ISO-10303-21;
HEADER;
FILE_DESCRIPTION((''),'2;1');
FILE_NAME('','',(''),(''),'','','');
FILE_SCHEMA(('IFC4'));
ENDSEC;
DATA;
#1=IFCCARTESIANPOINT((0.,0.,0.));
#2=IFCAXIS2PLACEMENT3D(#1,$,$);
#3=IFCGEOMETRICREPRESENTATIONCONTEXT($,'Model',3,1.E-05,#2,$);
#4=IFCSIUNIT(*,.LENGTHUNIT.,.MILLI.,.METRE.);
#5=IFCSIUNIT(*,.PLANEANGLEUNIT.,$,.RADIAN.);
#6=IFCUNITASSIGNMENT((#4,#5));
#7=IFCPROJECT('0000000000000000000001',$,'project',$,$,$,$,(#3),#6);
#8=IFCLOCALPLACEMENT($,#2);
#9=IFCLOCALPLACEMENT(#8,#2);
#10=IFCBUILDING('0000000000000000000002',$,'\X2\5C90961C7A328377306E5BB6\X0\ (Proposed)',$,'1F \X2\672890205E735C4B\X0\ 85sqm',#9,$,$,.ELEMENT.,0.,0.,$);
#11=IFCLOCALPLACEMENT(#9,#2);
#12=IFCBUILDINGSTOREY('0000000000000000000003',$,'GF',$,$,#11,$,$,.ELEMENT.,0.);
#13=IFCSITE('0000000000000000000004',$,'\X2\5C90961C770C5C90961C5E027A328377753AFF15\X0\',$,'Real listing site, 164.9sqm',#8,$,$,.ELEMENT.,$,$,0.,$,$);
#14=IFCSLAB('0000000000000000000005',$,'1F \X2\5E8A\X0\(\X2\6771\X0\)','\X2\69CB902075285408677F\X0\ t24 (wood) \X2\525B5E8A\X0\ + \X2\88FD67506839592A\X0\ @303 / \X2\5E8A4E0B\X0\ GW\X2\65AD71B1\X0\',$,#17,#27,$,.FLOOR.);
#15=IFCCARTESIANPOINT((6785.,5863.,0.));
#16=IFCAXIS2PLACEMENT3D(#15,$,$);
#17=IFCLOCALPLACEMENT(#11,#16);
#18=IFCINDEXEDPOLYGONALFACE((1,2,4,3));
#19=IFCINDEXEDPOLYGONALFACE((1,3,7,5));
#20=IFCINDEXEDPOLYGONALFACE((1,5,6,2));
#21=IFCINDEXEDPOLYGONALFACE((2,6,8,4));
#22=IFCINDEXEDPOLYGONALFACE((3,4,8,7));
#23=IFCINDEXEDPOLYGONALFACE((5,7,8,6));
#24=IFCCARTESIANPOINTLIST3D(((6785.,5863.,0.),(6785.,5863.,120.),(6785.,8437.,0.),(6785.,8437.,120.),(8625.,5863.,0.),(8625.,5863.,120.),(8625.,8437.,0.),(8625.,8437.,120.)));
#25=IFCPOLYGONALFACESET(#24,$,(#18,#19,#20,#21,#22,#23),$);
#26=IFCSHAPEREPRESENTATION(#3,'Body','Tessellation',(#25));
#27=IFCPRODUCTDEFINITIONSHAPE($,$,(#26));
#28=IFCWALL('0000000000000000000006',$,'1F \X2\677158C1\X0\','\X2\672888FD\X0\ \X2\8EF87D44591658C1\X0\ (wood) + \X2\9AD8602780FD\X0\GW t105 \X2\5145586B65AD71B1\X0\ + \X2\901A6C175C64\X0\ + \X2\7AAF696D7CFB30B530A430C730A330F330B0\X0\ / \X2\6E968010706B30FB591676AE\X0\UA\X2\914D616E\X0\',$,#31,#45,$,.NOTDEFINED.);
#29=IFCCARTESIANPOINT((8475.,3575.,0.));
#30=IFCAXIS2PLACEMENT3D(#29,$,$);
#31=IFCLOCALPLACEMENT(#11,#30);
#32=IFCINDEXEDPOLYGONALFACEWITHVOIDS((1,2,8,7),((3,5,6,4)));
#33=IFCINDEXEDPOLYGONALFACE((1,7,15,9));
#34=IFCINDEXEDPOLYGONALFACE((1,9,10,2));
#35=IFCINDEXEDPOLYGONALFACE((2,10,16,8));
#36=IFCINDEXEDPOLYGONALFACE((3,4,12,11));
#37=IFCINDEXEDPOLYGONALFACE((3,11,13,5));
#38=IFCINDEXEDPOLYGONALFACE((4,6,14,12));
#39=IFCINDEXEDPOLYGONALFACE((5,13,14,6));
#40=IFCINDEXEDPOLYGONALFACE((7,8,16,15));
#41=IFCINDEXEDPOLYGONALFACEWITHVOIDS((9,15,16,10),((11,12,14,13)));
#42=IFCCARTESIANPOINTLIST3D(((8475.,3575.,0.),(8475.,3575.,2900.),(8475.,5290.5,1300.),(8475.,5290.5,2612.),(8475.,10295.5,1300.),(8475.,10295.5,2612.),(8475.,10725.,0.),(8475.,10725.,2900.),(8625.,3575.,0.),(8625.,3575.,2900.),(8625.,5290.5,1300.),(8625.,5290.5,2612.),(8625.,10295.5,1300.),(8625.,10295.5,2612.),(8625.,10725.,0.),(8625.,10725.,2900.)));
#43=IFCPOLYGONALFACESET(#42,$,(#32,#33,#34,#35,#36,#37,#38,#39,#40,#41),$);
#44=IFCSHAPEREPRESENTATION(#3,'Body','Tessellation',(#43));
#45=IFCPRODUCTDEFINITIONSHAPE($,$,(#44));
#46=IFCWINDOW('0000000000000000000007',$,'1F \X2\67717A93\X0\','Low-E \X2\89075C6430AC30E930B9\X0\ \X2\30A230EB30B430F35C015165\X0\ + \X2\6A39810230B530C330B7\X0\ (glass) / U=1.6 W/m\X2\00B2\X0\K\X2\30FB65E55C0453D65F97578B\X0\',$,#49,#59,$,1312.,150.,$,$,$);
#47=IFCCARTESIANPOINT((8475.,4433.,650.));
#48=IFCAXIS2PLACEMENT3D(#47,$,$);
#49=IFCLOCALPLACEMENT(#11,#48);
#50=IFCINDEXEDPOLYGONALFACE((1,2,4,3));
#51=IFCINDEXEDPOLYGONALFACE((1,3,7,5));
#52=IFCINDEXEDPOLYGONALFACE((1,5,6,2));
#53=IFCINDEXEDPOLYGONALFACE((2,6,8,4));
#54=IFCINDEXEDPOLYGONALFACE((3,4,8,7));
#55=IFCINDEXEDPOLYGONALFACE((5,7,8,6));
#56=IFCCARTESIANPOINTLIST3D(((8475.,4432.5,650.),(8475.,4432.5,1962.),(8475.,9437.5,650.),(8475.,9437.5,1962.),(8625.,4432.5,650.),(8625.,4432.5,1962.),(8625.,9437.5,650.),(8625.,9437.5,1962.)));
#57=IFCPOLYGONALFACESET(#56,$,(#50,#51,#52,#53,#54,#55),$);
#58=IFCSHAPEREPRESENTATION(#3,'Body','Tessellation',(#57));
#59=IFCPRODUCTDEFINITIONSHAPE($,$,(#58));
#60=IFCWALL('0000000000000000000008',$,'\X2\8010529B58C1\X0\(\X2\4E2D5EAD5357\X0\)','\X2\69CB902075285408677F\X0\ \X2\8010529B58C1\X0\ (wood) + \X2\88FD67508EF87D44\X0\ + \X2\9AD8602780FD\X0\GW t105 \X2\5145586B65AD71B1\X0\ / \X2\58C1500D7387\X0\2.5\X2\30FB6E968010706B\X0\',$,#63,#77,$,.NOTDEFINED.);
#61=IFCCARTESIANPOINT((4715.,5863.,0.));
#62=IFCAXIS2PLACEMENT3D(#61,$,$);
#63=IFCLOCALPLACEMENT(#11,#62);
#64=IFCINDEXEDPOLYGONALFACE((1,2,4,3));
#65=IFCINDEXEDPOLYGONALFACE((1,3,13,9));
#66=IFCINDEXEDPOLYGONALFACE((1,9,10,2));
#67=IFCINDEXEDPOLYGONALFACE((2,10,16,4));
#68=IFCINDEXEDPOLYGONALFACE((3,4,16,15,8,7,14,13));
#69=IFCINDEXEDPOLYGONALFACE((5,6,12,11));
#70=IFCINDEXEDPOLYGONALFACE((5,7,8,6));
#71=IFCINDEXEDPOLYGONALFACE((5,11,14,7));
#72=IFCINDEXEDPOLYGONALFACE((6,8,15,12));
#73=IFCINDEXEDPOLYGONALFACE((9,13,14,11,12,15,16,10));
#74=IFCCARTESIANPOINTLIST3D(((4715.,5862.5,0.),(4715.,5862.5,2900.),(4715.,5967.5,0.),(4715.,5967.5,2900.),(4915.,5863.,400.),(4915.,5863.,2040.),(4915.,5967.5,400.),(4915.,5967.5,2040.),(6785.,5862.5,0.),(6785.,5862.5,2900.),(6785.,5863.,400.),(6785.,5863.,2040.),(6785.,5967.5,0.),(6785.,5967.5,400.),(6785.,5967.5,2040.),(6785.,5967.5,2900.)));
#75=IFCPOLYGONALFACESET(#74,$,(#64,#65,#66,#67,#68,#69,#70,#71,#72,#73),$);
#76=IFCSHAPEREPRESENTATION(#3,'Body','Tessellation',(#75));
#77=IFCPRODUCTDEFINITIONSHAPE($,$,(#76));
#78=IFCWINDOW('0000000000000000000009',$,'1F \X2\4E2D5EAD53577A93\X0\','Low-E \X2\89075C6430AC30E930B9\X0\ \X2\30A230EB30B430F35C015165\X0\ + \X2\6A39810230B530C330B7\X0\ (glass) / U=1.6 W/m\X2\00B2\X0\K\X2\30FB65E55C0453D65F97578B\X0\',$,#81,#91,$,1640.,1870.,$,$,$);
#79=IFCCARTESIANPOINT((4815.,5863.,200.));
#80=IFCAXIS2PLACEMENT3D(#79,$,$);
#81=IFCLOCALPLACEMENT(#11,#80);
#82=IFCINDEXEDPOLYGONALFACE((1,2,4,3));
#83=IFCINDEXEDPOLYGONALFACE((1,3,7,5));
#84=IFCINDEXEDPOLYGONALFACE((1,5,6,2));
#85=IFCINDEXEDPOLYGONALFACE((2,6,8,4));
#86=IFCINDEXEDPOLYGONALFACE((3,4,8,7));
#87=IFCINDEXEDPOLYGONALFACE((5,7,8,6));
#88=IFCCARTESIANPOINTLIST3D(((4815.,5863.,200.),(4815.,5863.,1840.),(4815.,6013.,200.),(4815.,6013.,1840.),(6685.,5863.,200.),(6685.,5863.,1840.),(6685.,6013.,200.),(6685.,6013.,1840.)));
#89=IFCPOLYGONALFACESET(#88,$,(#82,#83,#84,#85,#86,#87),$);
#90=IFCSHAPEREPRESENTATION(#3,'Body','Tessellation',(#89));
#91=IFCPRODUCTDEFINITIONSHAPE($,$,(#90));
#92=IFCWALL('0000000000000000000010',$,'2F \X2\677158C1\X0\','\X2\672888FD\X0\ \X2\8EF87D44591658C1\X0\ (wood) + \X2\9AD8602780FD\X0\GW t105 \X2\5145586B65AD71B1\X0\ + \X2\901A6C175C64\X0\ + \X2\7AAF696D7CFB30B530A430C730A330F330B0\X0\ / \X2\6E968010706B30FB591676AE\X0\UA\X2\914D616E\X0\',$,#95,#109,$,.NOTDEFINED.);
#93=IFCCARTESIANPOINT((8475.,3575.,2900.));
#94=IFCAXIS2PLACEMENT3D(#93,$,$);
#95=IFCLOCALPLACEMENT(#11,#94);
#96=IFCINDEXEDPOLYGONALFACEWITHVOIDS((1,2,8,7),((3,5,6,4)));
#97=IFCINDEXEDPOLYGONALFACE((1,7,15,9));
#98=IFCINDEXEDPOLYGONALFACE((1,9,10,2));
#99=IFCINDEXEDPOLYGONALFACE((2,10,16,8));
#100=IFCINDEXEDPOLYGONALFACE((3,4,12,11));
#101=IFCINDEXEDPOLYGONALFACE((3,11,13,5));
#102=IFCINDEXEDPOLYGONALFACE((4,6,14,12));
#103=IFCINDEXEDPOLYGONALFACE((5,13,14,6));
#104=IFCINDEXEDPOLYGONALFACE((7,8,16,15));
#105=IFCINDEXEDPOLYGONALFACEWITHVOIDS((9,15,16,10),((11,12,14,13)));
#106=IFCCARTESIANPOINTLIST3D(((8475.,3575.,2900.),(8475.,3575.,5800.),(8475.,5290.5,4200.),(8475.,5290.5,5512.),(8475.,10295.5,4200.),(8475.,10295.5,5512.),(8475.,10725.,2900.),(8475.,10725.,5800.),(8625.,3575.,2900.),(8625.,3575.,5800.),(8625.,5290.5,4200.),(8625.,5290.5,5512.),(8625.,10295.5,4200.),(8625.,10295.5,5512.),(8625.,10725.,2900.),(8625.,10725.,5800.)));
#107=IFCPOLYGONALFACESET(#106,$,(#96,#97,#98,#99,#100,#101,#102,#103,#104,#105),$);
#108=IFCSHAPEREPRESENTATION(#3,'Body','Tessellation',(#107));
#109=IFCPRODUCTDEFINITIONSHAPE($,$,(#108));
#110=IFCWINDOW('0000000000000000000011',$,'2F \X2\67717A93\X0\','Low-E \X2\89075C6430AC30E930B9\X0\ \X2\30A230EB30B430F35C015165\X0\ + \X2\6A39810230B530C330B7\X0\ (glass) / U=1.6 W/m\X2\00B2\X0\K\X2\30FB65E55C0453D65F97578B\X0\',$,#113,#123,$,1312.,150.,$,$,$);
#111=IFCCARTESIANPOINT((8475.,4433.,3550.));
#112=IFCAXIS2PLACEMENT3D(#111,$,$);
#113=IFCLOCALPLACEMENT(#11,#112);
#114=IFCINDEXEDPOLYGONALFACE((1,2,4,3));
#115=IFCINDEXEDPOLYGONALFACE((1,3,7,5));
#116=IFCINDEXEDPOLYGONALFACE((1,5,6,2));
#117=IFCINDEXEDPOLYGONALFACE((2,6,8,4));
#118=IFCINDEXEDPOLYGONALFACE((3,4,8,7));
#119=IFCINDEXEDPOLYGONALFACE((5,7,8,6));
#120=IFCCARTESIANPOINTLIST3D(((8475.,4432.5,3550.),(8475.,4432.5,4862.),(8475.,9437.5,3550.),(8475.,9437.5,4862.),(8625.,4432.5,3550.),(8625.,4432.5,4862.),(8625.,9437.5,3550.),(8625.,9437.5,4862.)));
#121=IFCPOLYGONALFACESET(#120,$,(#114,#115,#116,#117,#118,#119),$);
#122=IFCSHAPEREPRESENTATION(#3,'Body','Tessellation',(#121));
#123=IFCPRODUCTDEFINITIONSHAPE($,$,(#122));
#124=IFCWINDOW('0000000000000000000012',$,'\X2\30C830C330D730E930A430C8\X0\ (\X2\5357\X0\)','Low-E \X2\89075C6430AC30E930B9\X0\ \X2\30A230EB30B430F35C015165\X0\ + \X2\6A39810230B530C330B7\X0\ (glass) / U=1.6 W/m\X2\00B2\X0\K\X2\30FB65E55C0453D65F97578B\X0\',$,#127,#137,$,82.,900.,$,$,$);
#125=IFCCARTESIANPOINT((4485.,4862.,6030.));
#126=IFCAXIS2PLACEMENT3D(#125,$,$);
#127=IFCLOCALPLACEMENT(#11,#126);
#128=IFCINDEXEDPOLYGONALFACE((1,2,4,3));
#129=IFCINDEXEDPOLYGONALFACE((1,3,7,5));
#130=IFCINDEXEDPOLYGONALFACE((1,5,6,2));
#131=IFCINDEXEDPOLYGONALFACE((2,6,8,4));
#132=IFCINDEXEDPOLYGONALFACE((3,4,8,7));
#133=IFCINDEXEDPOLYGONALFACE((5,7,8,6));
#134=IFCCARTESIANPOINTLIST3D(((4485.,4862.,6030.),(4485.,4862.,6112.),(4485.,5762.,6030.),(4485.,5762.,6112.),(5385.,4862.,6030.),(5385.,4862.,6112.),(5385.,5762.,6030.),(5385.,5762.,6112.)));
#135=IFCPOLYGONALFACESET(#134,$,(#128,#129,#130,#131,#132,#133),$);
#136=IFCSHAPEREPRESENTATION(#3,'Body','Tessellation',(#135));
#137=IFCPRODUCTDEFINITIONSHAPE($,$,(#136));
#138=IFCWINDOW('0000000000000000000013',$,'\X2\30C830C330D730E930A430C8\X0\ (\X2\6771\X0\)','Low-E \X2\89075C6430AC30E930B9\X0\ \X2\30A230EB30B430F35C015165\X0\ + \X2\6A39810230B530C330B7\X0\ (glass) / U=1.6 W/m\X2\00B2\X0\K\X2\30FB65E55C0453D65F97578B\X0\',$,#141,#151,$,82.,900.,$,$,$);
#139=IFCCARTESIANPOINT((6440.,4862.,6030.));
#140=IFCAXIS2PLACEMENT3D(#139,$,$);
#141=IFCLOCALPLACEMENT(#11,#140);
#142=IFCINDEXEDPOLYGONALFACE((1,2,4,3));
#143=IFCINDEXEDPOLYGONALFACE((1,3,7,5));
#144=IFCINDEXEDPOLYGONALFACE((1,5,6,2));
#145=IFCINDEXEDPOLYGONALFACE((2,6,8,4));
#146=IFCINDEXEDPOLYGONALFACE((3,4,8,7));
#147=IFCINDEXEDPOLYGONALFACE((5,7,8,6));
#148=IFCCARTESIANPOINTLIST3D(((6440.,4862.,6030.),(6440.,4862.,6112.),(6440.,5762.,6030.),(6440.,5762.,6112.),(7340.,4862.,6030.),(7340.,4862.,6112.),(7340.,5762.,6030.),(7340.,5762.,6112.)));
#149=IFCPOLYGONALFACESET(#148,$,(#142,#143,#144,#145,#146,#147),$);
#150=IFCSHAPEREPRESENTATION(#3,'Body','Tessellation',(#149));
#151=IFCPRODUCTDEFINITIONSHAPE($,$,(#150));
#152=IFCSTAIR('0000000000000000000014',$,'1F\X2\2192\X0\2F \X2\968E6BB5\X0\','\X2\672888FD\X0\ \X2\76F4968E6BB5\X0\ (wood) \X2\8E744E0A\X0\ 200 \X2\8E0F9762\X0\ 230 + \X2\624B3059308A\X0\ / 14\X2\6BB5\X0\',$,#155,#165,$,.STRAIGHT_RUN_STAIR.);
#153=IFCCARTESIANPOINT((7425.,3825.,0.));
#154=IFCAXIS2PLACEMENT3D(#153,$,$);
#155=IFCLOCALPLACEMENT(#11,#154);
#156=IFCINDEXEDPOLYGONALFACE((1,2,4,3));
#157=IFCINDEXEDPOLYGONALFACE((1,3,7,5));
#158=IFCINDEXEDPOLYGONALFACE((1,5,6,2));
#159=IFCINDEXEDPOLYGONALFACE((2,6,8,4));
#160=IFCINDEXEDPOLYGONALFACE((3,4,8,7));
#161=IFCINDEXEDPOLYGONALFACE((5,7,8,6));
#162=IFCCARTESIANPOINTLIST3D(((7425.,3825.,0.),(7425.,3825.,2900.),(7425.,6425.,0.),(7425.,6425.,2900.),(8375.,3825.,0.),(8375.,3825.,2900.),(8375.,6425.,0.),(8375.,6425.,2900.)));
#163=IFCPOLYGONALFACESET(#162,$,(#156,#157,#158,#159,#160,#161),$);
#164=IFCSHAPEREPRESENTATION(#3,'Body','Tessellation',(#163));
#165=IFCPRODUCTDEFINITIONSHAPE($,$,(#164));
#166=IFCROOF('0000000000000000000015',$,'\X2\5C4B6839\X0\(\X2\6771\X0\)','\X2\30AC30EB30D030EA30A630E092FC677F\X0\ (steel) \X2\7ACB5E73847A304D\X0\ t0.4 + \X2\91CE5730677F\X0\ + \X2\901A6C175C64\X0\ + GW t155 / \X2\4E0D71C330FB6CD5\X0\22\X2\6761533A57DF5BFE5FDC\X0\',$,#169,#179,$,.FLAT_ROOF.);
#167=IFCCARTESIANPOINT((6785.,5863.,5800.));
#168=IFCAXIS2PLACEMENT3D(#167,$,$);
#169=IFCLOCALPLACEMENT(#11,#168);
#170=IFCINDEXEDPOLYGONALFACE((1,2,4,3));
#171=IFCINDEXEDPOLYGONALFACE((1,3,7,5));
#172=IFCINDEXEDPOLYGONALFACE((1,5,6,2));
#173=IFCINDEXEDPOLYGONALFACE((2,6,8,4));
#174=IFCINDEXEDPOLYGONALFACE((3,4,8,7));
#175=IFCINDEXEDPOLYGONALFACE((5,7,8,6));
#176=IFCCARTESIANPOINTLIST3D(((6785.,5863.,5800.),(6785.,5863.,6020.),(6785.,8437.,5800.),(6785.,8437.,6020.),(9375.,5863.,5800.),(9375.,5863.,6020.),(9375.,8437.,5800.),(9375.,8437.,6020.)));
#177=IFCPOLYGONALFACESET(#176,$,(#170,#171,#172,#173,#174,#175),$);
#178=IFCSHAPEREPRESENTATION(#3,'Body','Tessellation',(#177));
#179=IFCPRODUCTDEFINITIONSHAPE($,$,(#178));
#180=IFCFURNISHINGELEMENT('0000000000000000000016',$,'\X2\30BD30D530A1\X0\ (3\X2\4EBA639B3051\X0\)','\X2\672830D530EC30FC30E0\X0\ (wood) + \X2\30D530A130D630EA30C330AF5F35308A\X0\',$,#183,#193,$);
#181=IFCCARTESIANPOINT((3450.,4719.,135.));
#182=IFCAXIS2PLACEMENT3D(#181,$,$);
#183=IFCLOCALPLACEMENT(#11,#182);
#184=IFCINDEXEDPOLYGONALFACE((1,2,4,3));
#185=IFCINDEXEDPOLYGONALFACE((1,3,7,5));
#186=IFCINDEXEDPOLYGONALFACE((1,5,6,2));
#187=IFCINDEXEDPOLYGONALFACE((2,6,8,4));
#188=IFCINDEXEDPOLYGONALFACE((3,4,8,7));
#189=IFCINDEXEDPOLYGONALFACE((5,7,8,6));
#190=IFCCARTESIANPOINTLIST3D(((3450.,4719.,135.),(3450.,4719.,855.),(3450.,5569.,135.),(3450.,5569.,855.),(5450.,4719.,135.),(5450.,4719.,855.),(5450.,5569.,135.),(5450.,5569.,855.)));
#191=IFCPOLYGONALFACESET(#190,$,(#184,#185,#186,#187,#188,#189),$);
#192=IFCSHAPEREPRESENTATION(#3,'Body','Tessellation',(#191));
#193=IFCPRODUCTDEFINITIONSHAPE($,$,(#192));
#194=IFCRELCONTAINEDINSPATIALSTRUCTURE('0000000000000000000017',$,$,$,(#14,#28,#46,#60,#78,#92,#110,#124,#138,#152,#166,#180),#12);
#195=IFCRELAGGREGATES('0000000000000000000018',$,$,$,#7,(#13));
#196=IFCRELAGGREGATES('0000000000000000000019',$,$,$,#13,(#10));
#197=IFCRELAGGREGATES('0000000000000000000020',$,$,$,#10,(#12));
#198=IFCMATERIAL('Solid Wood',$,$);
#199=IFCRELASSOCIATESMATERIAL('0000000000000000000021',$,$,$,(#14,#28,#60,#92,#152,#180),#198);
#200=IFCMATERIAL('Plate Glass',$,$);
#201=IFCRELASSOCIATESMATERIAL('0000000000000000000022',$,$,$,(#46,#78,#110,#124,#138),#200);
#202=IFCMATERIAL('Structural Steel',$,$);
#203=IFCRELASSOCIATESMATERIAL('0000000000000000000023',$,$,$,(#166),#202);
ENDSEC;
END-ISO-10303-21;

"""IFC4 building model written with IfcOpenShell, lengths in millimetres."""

from ifc_helpers import new_model, si_unit, frame, frame_2d, origin, place, context, project, spatial, rectangle, extrude, material, element, fill, save


model = new_model("IFC4")

# Units and contexts
model_context = context("Model", 3, precision=1e-05, world=origin())
ifc_project = project(units=[si_unit("LENGTHUNIT", "METRE", prefix="MILLI"), si_unit("PLANEANGLEUNIT", "RADIAN")], contexts=[model_context])

# Site, building, storey
site_placement = place(None, origin())
site = spatial("IfcSite", under=ifc_project, at=site_placement, Name="岐阜県岐阜市稲荷町５", ObjectType="Real listing site, 164.9sqm", CompositionType="ELEMENT", RefElevation=0.0)
building_placement = place(site_placement, origin())
building = spatial("IfcBuilding", under=site, at=building_placement, Name="岐阜稲荷の家 (Proposed)", ObjectType="1F 木造平屋 85sqm", CompositionType="ELEMENT", ElevationOfRefHeight=0.0, ElevationOfTerrain=0.0)
storey_placement = place(building_placement, origin())
storey = spatial("IfcBuildingStorey", under=building, at=storey_placement, Name="GF", CompositionType="ELEMENT", Elevation=0.0)

# Slab
ifc_material_1 = material(Name="Solid Wood")
slab_placement = place(storey_placement, frame((6785.0, 5863.0, 0.0)))
element("IfcSlab", 1, at=slab_placement, inside=storey, material=ifc_material_1, Name="1F 床(東)", Description="構造用合板 t24 (wood) 剛床 + 製材根太 @303 / 床下 GW断熱", PredefinedType="FLOOR", context=model_context, shape_type="SweptSolid", body=[
    extrude(rectangle(XDim=1840.0, YDim=2574.0, at=frame_2d((920.0, 1287.0))), frame((6785.0, 5863.0, 0.0)), (0.0, 0.0, 1.0), 120.0),
])

# Walls, openings, windows
wall_1_placement = place(storey_placement, frame((8475.0, 3575.0, 0.0)))
wall_1 = element("IfcWall", 2, at=wall_1_placement, inside=storey, material=ifc_material_1, Name="1F 東壁", Description="木製 軸組外壁 (wood) + 高性能GW t105 充填断熱 + 通気層 + 窯業系サイディング / 準耐火・外皮UA配慮", PredefinedType="NOTDEFINED", context=model_context, shape_type="SweptSolid", body=[
    extrude(rectangle(XDim=150.0, YDim=7150.0, at=frame_2d((75.0, 3575.0))), frame((8475.0, 3575.0, 0.0)), (0.0, 0.0, 1.0), 2900.0),
])
opening_1_placement = place(storey_placement, frame((8475.0, 4433.0, 650.0)))
opening_1 = element("IfcOpeningElement", 3, at=opening_1_placement, cuts=wall_1, PredefinedType="NOTDEFINED", context=model_context, shape_type="SweptSolid", body=[
    extrude(rectangle(XDim=150.0, YDim=5005.0, at=frame_2d((75.0, 2502.0))), frame((8475.0, 4433.0, 650.0)), (0.0, 0.0, 1.0), 1312.0),
])
ifc_material_2 = material(Name="Plate Glass")
window_1_placement = place(storey_placement, frame((8475.0, 4433.0, 650.0)))
window_1 = element("IfcWindow", 4, at=window_1_placement, inside=storey, material=ifc_material_2, Name="1F 東窓", Description="Low-E 複層ガラス アルゴン封入 + 樹脂サッシ (glass) / U=1.6 W/m²K・日射取得型", OverallHeight=1312.0, OverallWidth=150.0, context=model_context, shape_type="SweptSolid", body=[
    extrude(rectangle(XDim=150.0, YDim=5005.0, at=frame_2d((75.0, 2502.0))), frame((8475.0, 4433.0, 650.0)), (0.0, 0.0, 1.0), 1312.0),
])
fill(opening_1, window_1)
wall_2_placement = place(storey_placement, frame((4715.0, 5863.0, 0.0)))
wall_2 = element("IfcWall", 5, at=wall_2_placement, inside=storey, material=ifc_material_1, Name="耐力壁(中庭南)", Description="構造用合板 耐力壁 (wood) + 製材軸組 + 高性能GW t105 充填断熱 / 壁倍率2.5・準耐火", PredefinedType="NOTDEFINED", context=model_context, shape_type="SweptSolid", body=[
    extrude(rectangle(XDim=2070.0, YDim=105.0, at=frame_2d((1035.0, 52.0))), frame((4715.0, 5863.0, 0.0)), (0.0, 0.0, 1.0), 2900.0),
])
opening_2_placement = place(storey_placement, frame((4815.0, 5863.0, 200.0)))
opening_2 = element("IfcOpeningElement", 6, at=opening_2_placement, cuts=wall_2, PredefinedType="NOTDEFINED", context=model_context, shape_type="SweptSolid", body=[
    extrude(rectangle(XDim=1870.0, YDim=150.0, at=frame_2d((935.0, 75.0))), frame((4815.0, 5863.0, 200.0)), (0.0, 0.0, 1.0), 1640.0),
])
window_2_placement = place(storey_placement, frame((4815.0, 5863.0, 200.0)))
window_2 = element("IfcWindow", 7, at=window_2_placement, inside=storey, material=ifc_material_2, Name="1F 中庭南窓", Description="Low-E 複層ガラス アルゴン封入 + 樹脂サッシ (glass) / U=1.6 W/m²K・日射取得型", OverallHeight=1640.0, OverallWidth=1870.0, context=model_context, shape_type="SweptSolid", body=[
    extrude(rectangle(XDim=1870.0, YDim=150.0, at=frame_2d((935.0, 75.0))), frame((4815.0, 5863.0, 200.0)), (0.0, 0.0, 1.0), 1640.0),
])
fill(opening_2, window_2)

# Wall, opening, window
wall_3_placement = place(storey_placement, frame((8475.0, 3575.0, 2900.0)))
wall_3 = element("IfcWall", 8, at=wall_3_placement, inside=storey, material=ifc_material_1, Name="2F 東壁", Description="木製 軸組外壁 (wood) + 高性能GW t105 充填断熱 + 通気層 + 窯業系サイディング / 準耐火・外皮UA配慮", PredefinedType="NOTDEFINED", context=model_context, shape_type="SweptSolid", body=[
    extrude(rectangle(XDim=150.0, YDim=7150.0, at=frame_2d((75.0, 3575.0))), frame((8475.0, 3575.0, 2900.0)), (0.0, 0.0, 1.0), 2900.0),
])
opening_3_placement = place(storey_placement, frame((8475.0, 4433.0, 3550.0)))
opening_3 = element("IfcOpeningElement", 9, at=opening_3_placement, cuts=wall_3, PredefinedType="NOTDEFINED", context=model_context, shape_type="SweptSolid", body=[
    extrude(rectangle(XDim=150.0, YDim=5005.0, at=frame_2d((75.0, 2502.0))), frame((8475.0, 4433.0, 3550.0)), (0.0, 0.0, 1.0), 1312.0),
])
window_3_placement = place(storey_placement, frame((8475.0, 4433.0, 3550.0)))
window_3 = element("IfcWindow", 10, at=window_3_placement, inside=storey, material=ifc_material_2, Name="2F 東窓", Description="Low-E 複層ガラス アルゴン封入 + 樹脂サッシ (glass) / U=1.6 W/m²K・日射取得型", OverallHeight=1312.0, OverallWidth=150.0, context=model_context, shape_type="SweptSolid", body=[
    extrude(rectangle(XDim=150.0, YDim=5005.0, at=frame_2d((75.0, 2502.0))), frame((8475.0, 4433.0, 3550.0)), (0.0, 0.0, 1.0), 1312.0),
])
fill(opening_3, window_3)

# Windows
window_4_placement = place(storey_placement, frame((4485.0, 4862.0, 6030.0)))
element("IfcWindow", 11, at=window_4_placement, inside=storey, material=ifc_material_2, Name="トップライト (南)", Description="Low-E 複層ガラス アルゴン封入 + 樹脂サッシ (glass) / U=1.6 W/m²K・日射取得型", OverallHeight=82.0, OverallWidth=900.0, context=model_context, shape_type="SweptSolid", body=[
    extrude(rectangle(XDim=900.0, YDim=900.0, at=frame_2d((450.0, 450.0))), frame((4485.0, 4862.0, 6030.0)), (0.0, 0.0, 1.0), 82.0),
])
window_5_placement = place(storey_placement, frame((6440.0, 4862.0, 6030.0)))
element("IfcWindow", 12, at=window_5_placement, inside=storey, material=ifc_material_2, Name="トップライト (東)", Description="Low-E 複層ガラス アルゴン封入 + 樹脂サッシ (glass) / U=1.6 W/m²K・日射取得型", OverallHeight=82.0, OverallWidth=900.0, context=model_context, shape_type="SweptSolid", body=[
    extrude(rectangle(XDim=900.0, YDim=900.0, at=frame_2d((450.0, 450.0))), frame((6440.0, 4862.0, 6030.0)), (0.0, 0.0, 1.0), 82.0),
])

# Stair
stair_placement = place(storey_placement, frame((7425.0, 3825.0, 0.0)))
element("IfcStair", 13, at=stair_placement, inside=storey, material=ifc_material_1, Name="1F→2F 階段", Description="木製 直階段 (wood) 蹴上 200 踏面 230 + 手すり / 14段", PredefinedType="STRAIGHT_RUN_STAIR", context=model_context, shape_type="SweptSolid", body=[
    extrude(rectangle(XDim=950.0, YDim=2600.0, at=frame_2d((475.0, 1300.0))), frame((7425.0, 3825.0, 0.0)), (0.0, 0.0, 1.0), 2900.0),
])

# Roof
ifc_material_3 = material(Name="Structural Steel")
roof_placement = place(storey_placement, frame((6785.0, 5863.0, 5800.0)))
element("IfcRoof", 14, at=roof_placement, inside=storey, material=ifc_material_3, Name="屋根(東)", Description="ガルバリウム鋼板 (steel) 立平葺き t0.4 + 野地板 + 通気層 + GW t155 / 不燃・法22条区域対応", PredefinedType="FLAT_ROOF", context=model_context, shape_type="SweptSolid", body=[
    extrude(rectangle(XDim=2590.0, YDim=2574.0, at=frame_2d((1295.0, 1287.0))), frame((6785.0, 5863.0, 5800.0)), (0.0, 0.0, 1.0), 220.0),
])

# Furnishing element
furnishing_1_placement = place(storey_placement, frame((3450.0, 4719.0, 135.0)))
element("IfcFurnishingElement", 15, at=furnishing_1_placement, inside=storey, material=ifc_material_1, Name="ソファ (3人掛け)", Description="木フレーム (wood) + ファブリック張り", context=model_context, shape_type="SweptSolid", body=[
    extrude(rectangle(XDim=2000.0, YDim=850.0, at=frame_2d((1000.0, 425.0))), frame((3450.0, 4719.0, 135.0)), (0.0, 0.0, 1.0), 720.0),
])

save(model, "model.ifc")
